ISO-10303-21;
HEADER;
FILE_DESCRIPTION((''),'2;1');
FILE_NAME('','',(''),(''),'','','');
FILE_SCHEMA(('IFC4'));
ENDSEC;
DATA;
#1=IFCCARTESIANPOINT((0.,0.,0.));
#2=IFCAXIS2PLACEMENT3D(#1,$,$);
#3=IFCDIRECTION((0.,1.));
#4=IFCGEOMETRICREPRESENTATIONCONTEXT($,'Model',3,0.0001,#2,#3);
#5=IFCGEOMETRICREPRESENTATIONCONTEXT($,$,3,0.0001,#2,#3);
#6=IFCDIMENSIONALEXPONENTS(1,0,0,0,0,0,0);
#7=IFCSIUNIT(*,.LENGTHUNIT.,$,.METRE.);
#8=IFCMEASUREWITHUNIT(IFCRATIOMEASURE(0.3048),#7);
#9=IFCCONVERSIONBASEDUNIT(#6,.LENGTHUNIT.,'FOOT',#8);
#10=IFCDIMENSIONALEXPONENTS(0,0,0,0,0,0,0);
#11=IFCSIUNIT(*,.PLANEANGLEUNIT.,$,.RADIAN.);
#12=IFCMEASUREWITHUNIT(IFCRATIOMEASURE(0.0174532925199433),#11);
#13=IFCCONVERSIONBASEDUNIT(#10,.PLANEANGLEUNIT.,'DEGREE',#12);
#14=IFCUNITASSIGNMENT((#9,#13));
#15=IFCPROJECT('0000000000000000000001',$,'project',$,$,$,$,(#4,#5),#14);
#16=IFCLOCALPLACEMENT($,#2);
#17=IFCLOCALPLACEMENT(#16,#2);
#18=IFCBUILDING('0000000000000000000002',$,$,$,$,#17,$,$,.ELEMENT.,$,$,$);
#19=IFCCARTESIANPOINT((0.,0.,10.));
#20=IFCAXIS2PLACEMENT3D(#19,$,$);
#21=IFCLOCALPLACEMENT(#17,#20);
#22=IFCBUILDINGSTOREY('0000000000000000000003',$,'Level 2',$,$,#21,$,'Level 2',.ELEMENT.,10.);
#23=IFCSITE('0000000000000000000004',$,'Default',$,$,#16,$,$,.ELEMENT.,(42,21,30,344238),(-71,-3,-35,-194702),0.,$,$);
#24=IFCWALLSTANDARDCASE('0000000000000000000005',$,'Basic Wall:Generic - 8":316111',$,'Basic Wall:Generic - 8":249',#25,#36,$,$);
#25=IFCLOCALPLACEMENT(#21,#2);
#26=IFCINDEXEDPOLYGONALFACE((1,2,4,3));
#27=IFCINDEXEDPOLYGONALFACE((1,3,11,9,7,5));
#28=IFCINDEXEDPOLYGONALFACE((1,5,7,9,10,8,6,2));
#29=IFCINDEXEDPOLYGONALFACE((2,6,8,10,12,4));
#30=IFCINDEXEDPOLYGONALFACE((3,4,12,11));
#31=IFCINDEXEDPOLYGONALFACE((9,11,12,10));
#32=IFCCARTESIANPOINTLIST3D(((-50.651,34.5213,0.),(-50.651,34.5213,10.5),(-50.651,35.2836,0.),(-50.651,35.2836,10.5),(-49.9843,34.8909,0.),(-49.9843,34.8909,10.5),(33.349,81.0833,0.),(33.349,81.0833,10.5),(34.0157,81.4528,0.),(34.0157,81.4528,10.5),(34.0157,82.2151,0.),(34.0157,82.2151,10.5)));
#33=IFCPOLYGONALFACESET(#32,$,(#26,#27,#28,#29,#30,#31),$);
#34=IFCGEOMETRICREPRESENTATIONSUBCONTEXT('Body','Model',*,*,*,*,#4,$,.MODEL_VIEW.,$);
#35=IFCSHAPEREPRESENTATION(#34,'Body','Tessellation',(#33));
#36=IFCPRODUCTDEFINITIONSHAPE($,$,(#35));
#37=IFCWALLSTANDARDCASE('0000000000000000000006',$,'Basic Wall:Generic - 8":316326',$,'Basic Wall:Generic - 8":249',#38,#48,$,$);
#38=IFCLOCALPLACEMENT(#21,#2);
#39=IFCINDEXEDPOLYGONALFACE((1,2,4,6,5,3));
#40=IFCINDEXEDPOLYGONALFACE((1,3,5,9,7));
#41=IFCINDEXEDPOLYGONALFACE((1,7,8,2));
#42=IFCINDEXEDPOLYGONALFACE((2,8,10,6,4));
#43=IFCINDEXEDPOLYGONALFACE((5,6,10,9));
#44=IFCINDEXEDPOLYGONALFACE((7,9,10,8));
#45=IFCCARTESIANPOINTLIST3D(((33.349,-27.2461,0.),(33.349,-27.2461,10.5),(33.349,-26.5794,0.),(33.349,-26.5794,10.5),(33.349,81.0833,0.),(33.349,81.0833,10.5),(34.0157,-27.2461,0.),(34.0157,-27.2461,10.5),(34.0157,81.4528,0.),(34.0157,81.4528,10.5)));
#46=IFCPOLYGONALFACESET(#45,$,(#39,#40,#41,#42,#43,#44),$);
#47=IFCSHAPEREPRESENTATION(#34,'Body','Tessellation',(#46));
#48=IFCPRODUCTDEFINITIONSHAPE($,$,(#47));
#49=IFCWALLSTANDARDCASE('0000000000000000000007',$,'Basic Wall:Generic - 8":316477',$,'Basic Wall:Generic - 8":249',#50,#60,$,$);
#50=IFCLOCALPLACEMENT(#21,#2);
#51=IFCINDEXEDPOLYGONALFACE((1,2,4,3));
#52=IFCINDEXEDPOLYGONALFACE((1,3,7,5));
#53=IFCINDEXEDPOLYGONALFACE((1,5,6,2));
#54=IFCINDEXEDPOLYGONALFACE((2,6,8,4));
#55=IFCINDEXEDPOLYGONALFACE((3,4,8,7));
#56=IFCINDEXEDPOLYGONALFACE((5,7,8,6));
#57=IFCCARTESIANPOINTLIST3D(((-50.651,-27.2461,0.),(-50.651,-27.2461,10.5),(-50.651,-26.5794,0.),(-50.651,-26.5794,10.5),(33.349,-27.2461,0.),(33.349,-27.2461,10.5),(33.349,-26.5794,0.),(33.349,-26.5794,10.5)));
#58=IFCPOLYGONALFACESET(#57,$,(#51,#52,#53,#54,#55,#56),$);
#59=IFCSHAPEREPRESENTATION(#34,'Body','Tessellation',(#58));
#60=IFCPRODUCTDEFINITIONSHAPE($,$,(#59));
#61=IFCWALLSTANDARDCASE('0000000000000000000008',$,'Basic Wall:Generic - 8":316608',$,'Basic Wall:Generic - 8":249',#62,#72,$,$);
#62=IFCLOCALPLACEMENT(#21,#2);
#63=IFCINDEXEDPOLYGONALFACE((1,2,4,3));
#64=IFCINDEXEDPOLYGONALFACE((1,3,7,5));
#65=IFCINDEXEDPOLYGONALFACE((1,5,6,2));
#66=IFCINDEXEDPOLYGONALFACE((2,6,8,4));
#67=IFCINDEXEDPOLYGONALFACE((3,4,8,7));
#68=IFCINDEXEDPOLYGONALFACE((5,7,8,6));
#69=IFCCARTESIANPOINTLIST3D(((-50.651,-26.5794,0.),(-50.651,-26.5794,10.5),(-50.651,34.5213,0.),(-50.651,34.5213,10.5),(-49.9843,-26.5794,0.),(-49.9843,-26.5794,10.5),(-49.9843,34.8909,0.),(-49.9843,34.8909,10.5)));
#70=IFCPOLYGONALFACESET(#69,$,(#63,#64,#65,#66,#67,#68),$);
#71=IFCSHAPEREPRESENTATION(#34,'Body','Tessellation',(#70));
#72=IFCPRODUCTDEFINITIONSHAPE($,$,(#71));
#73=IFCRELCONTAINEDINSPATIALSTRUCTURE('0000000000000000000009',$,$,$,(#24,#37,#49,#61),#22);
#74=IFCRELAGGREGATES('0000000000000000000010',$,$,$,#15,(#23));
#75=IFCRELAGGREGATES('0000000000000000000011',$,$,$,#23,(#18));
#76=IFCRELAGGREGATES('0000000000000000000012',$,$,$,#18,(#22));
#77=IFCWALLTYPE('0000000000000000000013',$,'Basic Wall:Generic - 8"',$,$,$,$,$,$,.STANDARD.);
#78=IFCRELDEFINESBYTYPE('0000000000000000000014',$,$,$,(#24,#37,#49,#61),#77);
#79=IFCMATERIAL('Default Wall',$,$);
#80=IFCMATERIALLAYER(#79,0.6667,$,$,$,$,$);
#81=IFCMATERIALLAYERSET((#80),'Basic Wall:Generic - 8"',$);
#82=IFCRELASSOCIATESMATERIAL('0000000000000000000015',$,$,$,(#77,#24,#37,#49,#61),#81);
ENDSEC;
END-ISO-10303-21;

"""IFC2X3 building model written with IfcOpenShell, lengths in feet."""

from ifc_helpers import new_model, entity, si_unit, converted_unit, direction, frame, frame_2d, origin, place, context, subcontext, project, spatial, polyline, rectangle, outline, extrude, material, layer, layer_set, layer_usage, type_object, element, save


model = new_model("IFC2X3")

# Units and contexts
model_context = context("Model", 3, precision=0.0001, world=origin(), true_north=direction((0.0, 1.0)))
context_of_model = context(None, 3, precision=0.0001, world=origin(), true_north=direction((0.0, 1.0)))
body_context = subcontext(model_context, "Body", "Model", "MODEL_VIEW")
ifc_project = project(units=[converted_unit("LENGTHUNIT", "FOOT", entity("IfcRatioMeasure", 0.3048), si_unit("LENGTHUNIT", "METRE"), dimensions=[1, 0, 0, 0, 0, 0, 0]), converted_unit("PLANEANGLEUNIT", "DEGREE", entity("IfcRatioMeasure", 0.0174532925199433), si_unit("PLANEANGLEUNIT", "RADIAN"), dimensions=[0, 0, 0, 0, 0, 0, 0])], contexts=[model_context, context_of_model])

# Site, building, storey
site_placement = place(None, origin())
site = spatial("IfcSite", under=ifc_project, at=site_placement, Name="Default", CompositionType="ELEMENT", RefLatitude=(42, 21, 30, 344238), RefLongitude=(-71, -3, -35, -194702), RefElevation=0.0)
building_placement = place(site_placement, origin())
building = spatial("IfcBuilding", under=site, at=building_placement, CompositionType="ELEMENT")
storey_placement = place(building_placement, frame((0.0, 0.0, 10.0)))
storey = spatial("IfcBuildingStorey", under=building, at=storey_placement, Name="Level 2", LongName="Level 2", CompositionType="ELEMENT", Elevation=10.0)

# Walls
ifc_material_1 = material(Name="Default Wall")
ifc_layer_1 = layer(ifc_material_1, 0.6667)
ifc_layer_set_1 = layer_set([ifc_layer_1], Name="Basic Wall:Generic - 8\"")
ifc_layer_usage_1 = layer_usage(ifc_layer_set_1, "AXIS2", "NEGATIVE", 0.3333)
wall_type = type_object("IfcWallType", Name="Basic Wall:Generic - 8\"", PredefinedType="STANDARD", material=ifc_layer_set_1)
wall_1_placement = place(storey_placement, frame((-50.8126, 34.8129, 0.0), z_axis=(0.0, 0.0, 1.0), x_axis=(0.87462, 0.48481, 0.0)))
element("IfcWallStandardCase", 1, at=wall_1_placement, inside=storey, type_object=wall_type, material=ifc_layer_usage_1, Name="Basic Wall:Generic - 8\":316111", ObjectType="Basic Wall:Generic - 8\":249", context=body_context, shape_type="SweptSolid", body=[
    extrude(outline(polyline([(96.804, -0.3333), (97.1735, 0.3333), (0.3695, 0.3333), (0.0, -0.3333), (0.7622, -0.3333), (96.0417, -0.3333), (96.804, -0.3333)])), origin(), (0.0, 0.0, 1.0), 10.5),
])
ifc_layer_usage_2 = layer_usage(ifc_layer_set_1, "AXIS2", "NEGATIVE", 0.3333)
wall_2_placement = place(storey_placement, frame((33.6824, 81.4528, 0.0), z_axis=(0.0, 0.0, 1.0), x_axis=(0.0, -1.0, 0.0)))
element("IfcWallStandardCase", 2, at=wall_2_placement, inside=storey, type_object=wall_type, material=ifc_layer_usage_2, Name="Basic Wall:Generic - 8\":316326", ObjectType="Basic Wall:Generic - 8\":249", context=body_context, shape_type="SweptSolid", body=[
    extrude(outline(polyline([(108.6989, -0.3333), (108.6989, 0.3333), (0.0, 0.3333), (0.3695, -0.3333), (108.0323, -0.3333), (108.6989, -0.3333)])), origin(), (0.0, 0.0, 1.0), 10.5),
])
ifc_layer_usage_3 = layer_usage(ifc_layer_set_1, "AXIS2", "NEGATIVE", 0.3333)
wall_3_placement = place(storey_placement, frame((33.349, -26.9128, 0.0), z_axis=(0.0, 0.0, 1.0), x_axis=(-1.0, 0.0, 0.0)))
element("IfcWallStandardCase", 3, at=wall_3_placement, inside=storey, type_object=wall_type, material=ifc_layer_usage_3, Name="Basic Wall:Generic - 8\":316477", ObjectType="Basic Wall:Generic - 8\":249", context=body_context, shape_type="SweptSolid", body=[
    extrude(rectangle(XDim=84.0, YDim=0.6667, at=frame_2d((42.0, 0.0), x_axis=(-1.0, 0.0))), origin(), (0.0, 0.0, 1.0), 10.5),
])
ifc_layer_usage_4 = layer_usage(ifc_layer_set_1, "AXIS2", "NEGATIVE", 0.3333)
wall_4_placement = place(storey_placement, frame((-50.3176, -26.5794, 0.0), z_axis=(0.0, 0.0, 1.0), x_axis=(0.0, 1.0, 0.0)))
element("IfcWallStandardCase", 4, at=wall_4_placement, inside=storey, type_object=wall_type, material=ifc_layer_usage_4, Name="Basic Wall:Generic - 8\":316608", ObjectType="Basic Wall:Generic - 8\":249", context=body_context, shape_type="SweptSolid", body=[
    extrude(outline(polyline([(61.4703, -0.3333), (61.1008, 0.3333), (0.0, 0.3333), (0.0, -0.3333), (61.4703, -0.3333)])), origin(), (0.0, 0.0, 1.0), 10.5),
])

save(model, "model.ifc")
